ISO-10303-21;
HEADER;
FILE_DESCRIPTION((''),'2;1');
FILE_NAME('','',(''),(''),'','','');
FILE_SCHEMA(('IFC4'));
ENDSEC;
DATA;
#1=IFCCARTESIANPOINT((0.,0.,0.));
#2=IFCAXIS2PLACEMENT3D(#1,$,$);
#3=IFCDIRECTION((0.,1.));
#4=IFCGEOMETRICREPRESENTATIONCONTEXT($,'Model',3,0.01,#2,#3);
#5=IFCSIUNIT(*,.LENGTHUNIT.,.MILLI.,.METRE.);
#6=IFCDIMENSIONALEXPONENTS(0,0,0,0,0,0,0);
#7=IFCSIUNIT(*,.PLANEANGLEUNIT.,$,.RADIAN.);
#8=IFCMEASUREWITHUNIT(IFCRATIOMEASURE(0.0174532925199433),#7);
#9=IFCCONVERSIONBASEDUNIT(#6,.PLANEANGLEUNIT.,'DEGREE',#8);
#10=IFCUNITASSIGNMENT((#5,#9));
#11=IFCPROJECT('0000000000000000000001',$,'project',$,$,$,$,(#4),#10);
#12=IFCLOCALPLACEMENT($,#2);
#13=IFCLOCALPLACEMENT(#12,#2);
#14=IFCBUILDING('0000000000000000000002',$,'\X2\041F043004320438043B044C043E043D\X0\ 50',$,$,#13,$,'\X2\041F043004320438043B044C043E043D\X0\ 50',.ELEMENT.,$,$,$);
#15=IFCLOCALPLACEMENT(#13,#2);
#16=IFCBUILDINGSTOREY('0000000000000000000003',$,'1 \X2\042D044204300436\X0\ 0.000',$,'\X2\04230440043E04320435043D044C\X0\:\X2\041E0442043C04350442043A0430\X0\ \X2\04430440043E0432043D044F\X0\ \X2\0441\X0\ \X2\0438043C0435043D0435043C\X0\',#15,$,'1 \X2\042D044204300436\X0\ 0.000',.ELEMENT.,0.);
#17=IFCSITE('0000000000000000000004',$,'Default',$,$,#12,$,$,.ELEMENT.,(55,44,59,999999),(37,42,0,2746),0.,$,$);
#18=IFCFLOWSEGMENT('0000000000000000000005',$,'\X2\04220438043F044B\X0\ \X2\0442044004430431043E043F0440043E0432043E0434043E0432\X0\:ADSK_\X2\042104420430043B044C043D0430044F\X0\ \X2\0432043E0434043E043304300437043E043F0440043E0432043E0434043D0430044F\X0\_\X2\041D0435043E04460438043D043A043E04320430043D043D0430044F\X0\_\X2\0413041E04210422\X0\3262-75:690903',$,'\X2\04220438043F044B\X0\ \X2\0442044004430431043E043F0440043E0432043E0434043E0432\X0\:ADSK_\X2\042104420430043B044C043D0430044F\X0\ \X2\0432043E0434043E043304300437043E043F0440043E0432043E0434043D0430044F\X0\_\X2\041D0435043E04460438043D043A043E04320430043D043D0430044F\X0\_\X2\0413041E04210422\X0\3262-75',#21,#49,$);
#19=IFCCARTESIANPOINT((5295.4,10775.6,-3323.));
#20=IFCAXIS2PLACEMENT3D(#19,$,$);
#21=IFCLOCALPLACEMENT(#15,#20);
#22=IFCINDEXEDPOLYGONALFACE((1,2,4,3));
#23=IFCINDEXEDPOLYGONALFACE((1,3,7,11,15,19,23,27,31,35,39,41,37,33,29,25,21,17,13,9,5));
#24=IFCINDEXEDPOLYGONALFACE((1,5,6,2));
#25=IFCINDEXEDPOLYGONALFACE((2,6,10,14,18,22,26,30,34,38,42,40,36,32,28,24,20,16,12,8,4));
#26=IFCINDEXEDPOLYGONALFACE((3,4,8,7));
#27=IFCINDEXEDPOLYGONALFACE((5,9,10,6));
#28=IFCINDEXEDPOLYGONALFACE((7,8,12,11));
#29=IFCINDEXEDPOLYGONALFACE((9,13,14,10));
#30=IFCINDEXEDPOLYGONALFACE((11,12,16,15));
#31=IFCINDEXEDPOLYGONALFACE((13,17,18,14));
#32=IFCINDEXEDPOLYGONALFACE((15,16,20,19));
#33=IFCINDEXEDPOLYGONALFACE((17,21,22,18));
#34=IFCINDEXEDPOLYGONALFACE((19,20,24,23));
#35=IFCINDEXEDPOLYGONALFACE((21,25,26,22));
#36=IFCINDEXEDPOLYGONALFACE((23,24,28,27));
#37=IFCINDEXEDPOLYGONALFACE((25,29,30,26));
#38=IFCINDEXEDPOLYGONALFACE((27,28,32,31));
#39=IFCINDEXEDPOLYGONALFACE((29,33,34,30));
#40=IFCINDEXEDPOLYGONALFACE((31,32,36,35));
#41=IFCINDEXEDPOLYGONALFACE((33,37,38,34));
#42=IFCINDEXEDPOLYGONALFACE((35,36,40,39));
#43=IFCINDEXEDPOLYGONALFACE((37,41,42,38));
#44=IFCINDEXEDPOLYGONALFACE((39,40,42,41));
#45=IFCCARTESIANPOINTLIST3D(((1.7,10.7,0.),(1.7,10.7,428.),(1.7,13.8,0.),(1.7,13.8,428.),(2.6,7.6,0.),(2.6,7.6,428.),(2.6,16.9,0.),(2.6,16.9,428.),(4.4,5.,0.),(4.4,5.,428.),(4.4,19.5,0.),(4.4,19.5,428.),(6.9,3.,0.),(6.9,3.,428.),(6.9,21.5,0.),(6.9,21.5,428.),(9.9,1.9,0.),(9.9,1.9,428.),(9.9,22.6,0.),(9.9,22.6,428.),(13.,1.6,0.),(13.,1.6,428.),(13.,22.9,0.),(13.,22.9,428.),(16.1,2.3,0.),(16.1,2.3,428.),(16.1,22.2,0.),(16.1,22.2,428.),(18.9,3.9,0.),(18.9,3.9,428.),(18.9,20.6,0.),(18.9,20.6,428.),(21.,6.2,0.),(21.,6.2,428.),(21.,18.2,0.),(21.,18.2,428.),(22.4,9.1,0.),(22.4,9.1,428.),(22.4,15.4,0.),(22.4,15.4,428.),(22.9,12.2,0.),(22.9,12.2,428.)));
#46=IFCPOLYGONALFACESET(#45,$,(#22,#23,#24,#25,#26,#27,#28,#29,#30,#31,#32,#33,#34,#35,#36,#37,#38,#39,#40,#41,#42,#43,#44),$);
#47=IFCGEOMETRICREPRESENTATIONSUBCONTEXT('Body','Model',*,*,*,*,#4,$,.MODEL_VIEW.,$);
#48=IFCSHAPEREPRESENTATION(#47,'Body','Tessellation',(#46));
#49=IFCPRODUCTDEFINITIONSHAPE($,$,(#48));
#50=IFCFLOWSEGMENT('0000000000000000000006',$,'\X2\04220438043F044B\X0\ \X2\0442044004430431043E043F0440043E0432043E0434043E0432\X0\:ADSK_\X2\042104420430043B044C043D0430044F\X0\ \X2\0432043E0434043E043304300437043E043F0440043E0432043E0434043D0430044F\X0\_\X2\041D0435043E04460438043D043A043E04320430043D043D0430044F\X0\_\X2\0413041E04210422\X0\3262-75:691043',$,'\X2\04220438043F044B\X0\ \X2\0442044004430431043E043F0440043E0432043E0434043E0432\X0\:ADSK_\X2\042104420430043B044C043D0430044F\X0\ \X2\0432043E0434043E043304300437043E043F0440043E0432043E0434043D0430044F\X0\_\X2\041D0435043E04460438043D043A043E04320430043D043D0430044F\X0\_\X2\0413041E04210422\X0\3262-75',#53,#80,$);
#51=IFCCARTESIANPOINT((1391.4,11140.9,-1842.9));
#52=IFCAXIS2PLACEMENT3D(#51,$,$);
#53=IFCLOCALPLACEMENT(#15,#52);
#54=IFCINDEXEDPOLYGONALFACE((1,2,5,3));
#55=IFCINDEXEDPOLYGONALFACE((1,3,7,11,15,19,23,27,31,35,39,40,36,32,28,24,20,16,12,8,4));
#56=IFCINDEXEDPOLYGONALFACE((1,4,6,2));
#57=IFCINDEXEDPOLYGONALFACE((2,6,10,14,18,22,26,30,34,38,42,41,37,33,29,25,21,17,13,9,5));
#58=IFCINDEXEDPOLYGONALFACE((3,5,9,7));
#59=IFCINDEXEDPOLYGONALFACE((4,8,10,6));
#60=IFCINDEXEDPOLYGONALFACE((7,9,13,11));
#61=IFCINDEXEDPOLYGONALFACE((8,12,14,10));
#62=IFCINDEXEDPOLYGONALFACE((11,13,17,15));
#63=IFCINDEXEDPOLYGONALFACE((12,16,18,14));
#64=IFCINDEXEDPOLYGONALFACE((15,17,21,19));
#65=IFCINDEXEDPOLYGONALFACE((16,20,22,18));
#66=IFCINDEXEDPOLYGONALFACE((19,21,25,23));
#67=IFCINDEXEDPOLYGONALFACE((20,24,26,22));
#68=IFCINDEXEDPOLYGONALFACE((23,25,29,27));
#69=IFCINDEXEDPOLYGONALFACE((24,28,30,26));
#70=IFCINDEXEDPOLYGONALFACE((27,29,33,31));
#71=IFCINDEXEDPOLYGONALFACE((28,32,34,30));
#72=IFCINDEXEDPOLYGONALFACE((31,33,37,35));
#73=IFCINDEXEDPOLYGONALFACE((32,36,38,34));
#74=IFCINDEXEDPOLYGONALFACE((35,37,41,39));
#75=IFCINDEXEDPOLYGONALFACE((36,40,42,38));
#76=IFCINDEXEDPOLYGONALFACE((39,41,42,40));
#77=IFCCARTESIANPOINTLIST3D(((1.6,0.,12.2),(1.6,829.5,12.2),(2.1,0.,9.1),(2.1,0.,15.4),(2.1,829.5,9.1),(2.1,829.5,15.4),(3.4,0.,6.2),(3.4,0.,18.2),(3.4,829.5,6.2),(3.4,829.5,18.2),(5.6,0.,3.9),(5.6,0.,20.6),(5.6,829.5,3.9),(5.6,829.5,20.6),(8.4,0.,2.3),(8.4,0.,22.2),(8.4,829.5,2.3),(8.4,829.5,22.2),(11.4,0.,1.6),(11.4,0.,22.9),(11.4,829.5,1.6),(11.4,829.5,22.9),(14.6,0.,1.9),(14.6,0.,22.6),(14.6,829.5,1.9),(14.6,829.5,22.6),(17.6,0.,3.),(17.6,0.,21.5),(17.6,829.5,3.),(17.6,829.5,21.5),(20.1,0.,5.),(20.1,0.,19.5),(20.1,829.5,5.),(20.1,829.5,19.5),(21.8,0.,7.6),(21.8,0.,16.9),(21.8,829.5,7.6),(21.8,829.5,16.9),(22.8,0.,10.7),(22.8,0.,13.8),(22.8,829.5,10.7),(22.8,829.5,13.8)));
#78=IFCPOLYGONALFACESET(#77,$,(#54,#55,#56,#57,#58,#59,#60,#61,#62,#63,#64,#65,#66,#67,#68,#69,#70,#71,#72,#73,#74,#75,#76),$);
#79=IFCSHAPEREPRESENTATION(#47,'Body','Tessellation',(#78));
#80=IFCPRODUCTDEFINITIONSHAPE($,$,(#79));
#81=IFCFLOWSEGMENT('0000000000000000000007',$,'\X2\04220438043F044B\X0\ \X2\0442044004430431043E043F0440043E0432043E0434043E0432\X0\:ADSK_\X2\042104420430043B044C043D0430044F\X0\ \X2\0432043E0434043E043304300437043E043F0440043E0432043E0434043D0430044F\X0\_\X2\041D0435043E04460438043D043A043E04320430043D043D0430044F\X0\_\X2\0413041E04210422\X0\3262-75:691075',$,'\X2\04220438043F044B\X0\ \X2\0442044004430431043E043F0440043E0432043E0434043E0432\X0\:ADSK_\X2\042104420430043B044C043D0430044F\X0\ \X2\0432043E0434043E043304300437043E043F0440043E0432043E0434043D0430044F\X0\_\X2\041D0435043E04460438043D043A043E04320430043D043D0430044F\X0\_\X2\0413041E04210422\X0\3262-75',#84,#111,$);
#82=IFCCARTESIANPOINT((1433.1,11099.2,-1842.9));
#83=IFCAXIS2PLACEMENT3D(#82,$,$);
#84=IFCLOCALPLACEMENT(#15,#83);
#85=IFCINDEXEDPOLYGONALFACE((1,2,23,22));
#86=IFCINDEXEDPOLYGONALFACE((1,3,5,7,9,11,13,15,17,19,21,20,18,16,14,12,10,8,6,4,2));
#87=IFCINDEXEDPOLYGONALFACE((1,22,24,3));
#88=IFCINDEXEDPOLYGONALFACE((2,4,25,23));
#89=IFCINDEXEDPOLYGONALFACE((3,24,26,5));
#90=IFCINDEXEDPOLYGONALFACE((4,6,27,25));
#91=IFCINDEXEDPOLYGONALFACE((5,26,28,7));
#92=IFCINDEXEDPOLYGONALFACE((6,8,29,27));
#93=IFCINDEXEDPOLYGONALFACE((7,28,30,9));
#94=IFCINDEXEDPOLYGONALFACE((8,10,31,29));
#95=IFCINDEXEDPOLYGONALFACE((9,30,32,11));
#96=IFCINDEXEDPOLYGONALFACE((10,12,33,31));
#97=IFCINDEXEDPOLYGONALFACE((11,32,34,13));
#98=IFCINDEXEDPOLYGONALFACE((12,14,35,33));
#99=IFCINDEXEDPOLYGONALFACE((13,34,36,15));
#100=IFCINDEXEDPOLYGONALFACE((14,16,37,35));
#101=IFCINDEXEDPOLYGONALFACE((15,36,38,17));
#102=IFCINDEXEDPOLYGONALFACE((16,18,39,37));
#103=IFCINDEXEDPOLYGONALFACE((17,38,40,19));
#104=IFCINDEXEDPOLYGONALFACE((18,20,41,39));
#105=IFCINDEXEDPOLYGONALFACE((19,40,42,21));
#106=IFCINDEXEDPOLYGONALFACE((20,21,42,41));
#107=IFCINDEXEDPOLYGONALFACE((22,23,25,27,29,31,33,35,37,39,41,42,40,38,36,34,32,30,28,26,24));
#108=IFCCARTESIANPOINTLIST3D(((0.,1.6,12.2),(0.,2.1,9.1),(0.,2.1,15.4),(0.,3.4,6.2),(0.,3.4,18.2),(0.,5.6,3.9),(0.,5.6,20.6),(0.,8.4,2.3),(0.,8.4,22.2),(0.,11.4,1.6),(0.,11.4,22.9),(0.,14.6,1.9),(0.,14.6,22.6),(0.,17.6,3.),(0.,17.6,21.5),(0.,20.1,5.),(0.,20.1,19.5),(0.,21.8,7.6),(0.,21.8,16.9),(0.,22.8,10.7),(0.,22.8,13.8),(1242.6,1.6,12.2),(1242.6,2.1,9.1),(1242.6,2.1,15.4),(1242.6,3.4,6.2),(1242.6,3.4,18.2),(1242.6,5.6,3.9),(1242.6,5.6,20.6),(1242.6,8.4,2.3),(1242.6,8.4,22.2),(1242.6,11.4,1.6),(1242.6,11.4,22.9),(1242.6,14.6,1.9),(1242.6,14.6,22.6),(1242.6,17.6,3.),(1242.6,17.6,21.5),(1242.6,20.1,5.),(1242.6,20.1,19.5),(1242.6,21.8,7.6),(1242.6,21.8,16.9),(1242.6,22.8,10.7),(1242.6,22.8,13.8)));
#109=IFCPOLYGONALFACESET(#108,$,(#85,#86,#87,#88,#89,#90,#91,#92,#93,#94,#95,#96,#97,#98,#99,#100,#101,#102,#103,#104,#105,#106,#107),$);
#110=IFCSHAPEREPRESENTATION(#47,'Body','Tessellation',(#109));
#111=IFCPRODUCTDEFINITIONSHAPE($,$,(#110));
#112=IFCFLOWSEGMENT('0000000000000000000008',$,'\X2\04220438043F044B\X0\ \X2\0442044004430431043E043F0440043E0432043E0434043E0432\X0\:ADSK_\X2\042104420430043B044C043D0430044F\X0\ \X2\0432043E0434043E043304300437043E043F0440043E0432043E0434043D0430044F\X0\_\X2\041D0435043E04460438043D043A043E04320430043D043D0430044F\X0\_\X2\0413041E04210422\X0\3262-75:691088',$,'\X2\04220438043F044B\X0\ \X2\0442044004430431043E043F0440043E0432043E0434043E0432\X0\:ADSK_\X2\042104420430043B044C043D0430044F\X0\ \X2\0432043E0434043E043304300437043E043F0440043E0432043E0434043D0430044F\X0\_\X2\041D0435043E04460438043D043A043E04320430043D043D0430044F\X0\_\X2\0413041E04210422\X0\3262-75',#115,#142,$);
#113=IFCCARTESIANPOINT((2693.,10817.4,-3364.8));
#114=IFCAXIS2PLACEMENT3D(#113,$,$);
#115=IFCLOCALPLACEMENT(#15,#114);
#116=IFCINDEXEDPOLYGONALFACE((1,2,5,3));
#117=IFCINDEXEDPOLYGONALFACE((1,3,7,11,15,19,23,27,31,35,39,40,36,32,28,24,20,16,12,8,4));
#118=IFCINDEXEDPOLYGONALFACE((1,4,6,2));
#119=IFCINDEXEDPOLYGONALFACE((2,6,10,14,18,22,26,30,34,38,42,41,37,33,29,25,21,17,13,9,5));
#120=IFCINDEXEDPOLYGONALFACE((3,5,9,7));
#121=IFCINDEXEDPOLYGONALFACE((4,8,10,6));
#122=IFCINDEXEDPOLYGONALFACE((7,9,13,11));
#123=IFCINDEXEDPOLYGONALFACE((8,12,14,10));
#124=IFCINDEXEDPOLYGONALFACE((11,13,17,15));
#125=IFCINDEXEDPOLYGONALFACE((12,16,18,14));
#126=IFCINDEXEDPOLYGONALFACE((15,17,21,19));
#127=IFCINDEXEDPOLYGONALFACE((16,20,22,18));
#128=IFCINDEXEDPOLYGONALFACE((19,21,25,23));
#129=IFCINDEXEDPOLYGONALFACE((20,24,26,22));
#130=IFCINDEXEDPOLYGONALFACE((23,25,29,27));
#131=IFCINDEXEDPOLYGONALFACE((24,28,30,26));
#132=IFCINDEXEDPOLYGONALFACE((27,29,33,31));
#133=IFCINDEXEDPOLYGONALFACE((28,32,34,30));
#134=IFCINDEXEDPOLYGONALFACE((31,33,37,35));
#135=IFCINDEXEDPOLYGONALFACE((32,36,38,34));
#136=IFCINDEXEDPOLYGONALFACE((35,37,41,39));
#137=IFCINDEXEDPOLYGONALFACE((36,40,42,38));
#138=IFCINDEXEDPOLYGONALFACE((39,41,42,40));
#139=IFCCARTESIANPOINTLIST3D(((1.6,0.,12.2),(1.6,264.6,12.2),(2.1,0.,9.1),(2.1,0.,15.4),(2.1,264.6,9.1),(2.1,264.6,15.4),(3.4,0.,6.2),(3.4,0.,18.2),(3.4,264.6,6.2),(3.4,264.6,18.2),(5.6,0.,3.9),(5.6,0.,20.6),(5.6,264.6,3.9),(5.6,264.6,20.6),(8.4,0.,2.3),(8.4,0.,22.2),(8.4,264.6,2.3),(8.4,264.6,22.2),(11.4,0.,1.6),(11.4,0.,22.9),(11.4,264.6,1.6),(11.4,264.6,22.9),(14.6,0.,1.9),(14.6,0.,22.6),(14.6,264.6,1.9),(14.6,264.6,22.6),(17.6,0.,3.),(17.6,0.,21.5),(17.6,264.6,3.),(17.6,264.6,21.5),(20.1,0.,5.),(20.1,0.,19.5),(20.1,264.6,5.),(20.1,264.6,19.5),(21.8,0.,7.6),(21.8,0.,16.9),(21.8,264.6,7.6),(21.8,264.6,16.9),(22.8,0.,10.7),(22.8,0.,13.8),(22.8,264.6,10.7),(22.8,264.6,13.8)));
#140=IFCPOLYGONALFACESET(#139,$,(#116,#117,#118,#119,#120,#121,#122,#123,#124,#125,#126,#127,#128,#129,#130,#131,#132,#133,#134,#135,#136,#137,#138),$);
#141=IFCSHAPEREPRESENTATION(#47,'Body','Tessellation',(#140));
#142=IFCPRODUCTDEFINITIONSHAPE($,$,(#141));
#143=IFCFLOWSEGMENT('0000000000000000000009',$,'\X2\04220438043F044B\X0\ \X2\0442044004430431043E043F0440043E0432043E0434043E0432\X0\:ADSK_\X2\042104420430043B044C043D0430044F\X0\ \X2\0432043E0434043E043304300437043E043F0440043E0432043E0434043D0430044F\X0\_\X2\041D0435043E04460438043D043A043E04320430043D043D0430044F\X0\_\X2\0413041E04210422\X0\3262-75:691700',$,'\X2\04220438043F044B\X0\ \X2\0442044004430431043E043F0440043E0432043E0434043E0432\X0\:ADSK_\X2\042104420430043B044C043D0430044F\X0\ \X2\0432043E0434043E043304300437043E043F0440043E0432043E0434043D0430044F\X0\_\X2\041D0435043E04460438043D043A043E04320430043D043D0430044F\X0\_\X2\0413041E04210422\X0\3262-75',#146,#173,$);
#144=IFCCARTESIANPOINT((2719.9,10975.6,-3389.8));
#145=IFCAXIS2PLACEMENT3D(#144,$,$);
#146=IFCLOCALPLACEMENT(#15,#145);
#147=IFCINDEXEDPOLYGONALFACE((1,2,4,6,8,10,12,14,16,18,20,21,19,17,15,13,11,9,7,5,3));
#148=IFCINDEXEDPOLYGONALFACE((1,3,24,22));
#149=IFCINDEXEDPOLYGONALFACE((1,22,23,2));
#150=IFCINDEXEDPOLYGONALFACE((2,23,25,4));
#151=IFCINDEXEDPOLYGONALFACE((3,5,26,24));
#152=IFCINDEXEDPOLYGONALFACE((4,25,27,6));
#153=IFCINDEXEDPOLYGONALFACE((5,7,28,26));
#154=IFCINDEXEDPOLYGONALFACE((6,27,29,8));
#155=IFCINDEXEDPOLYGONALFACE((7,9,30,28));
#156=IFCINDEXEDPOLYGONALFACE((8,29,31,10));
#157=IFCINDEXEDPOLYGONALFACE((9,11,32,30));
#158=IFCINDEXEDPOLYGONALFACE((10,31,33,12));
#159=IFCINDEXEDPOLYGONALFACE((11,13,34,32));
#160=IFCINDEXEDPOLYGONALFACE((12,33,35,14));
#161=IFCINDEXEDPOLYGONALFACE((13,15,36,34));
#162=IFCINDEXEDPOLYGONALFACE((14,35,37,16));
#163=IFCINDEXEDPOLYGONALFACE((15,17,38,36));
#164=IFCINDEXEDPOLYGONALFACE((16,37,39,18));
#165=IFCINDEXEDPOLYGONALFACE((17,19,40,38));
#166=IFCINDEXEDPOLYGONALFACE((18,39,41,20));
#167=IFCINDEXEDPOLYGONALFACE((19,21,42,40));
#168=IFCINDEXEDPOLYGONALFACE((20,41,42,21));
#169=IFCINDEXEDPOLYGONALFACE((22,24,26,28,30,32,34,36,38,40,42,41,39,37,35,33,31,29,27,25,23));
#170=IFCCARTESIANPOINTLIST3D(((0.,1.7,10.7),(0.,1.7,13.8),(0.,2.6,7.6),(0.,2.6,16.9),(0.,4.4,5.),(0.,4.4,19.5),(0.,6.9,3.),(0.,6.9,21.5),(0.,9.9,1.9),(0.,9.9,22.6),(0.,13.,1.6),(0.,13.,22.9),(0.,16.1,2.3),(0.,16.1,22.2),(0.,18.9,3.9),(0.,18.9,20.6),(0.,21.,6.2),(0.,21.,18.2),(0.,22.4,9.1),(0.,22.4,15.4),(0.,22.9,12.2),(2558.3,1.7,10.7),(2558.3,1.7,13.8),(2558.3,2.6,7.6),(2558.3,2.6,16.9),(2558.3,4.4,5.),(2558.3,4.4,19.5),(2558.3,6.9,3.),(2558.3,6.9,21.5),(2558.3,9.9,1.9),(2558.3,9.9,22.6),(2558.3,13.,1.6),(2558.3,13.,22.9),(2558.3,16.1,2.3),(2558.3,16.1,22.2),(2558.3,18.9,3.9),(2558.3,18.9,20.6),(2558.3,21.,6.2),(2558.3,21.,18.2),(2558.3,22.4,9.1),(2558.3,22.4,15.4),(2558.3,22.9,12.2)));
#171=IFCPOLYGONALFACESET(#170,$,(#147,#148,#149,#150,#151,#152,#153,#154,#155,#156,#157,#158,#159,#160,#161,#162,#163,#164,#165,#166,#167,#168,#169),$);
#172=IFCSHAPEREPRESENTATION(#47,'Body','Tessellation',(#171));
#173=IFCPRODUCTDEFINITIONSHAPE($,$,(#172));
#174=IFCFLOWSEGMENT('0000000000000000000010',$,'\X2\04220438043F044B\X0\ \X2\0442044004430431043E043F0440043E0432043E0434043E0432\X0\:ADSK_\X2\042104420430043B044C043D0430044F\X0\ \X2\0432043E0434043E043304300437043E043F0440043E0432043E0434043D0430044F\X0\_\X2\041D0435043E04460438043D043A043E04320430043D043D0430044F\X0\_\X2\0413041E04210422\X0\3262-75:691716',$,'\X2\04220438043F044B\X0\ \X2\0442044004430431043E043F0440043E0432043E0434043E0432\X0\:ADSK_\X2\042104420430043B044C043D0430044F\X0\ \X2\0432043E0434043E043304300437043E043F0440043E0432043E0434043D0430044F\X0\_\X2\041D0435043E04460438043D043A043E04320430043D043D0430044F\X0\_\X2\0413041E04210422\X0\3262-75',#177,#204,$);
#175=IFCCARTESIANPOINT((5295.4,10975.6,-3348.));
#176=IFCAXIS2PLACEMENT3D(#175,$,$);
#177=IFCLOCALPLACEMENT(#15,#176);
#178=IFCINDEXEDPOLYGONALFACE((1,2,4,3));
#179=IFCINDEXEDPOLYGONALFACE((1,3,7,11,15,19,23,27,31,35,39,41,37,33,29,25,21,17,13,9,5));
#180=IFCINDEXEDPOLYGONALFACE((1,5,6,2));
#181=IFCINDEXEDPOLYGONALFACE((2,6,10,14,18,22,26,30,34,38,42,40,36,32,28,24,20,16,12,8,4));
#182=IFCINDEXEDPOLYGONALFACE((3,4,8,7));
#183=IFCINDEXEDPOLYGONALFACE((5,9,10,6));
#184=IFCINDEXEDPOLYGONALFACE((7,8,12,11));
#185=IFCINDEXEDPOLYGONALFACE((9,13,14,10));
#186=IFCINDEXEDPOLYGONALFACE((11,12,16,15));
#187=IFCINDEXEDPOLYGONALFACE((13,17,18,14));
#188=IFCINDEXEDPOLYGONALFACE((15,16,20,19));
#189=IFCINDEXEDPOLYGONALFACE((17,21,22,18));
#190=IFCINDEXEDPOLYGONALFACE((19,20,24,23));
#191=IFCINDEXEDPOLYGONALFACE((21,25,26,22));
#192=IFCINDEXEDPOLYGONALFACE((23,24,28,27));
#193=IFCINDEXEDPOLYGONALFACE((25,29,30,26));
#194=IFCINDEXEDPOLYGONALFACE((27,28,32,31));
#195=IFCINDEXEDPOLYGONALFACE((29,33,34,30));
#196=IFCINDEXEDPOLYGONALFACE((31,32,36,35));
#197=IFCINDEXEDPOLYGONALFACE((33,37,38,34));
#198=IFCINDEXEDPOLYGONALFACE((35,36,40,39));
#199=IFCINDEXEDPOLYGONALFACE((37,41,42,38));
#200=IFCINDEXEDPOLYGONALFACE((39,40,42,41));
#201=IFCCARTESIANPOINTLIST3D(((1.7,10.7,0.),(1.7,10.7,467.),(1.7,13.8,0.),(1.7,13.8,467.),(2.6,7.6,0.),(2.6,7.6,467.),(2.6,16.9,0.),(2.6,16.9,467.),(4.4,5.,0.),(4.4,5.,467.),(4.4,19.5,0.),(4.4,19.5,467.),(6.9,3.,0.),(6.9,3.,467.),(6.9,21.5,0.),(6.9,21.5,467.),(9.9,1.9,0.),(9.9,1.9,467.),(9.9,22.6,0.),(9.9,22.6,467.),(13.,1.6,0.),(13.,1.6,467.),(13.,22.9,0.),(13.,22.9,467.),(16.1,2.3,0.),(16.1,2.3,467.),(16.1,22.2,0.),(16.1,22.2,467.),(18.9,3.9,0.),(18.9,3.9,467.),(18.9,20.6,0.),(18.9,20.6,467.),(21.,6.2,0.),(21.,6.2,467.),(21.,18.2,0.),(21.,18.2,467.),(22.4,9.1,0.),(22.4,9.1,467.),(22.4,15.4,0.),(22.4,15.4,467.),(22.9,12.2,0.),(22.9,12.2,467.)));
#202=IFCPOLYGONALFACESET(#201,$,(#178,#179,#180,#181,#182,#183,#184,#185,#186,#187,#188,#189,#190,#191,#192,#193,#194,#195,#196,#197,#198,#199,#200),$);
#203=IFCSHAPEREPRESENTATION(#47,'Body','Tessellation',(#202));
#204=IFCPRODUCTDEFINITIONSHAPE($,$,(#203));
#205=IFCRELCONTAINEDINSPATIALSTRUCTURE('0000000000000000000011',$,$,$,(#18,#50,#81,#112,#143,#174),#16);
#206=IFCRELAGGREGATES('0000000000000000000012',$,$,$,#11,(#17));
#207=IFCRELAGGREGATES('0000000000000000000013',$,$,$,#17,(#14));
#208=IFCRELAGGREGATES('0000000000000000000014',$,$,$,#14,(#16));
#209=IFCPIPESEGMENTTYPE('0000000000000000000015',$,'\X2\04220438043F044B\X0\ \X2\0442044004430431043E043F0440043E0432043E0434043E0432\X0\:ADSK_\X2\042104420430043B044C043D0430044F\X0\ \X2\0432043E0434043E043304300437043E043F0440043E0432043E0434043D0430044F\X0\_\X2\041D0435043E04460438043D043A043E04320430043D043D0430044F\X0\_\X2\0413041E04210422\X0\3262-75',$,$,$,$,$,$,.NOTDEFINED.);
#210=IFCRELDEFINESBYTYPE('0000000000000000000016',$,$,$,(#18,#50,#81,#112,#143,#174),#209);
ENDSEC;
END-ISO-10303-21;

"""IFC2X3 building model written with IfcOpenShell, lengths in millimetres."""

from ifc_helpers import new_model, entity, si_unit, converted_unit, direction, frame, frame_2d, origin, origin_2d_with_axis, place, context, subcontext, project, spatial, circle, extrude, type_object, element, save


model = new_model("IFC2X3")

# Units and contexts
model_context = context("Model", 3, precision=0.01, world=origin(), true_north=direction((0.0, 1.0)))
body_context = subcontext(model_context, "Body", "Model", "MODEL_VIEW")
ifc_project = project(units=[si_unit("LENGTHUNIT", "METRE", prefix="MILLI"), converted_unit("PLANEANGLEUNIT", "DEGREE", entity("IfcRatioMeasure", 0.0174532925199433), si_unit("PLANEANGLEUNIT", "RADIAN"), dimensions=[0, 0, 0, 0, 0, 0, 0])], contexts=[model_context])

# Site, building, storey
site_placement = place(None, origin())
site = spatial("IfcSite", under=ifc_project, at=site_placement, Name="Default", CompositionType="ELEMENT", RefLatitude=(55, 44, 59, 999999), RefLongitude=(37, 42, 0, 2746), RefElevation=0.0)
building_placement = place(site_placement, origin())
building = spatial("IfcBuilding", under=site, at=building_placement, Name="Павильон 50", LongName="Павильон 50", CompositionType="ELEMENT")
storey_placement = place(building_placement, origin())
storey = spatial("IfcBuildingStorey", under=building, at=storey_placement, Name="1 Этаж 0.000", ObjectType="Уровень:Отметка уровня с именем", LongName="1 Этаж 0.000", CompositionType="ELEMENT", Elevation=0.0)

# Flow segments
pipe_segment_type = type_object("IfcPipeSegmentType", Name="Типы трубопроводов:ADSK_Стальная водогазопроводная_Неоцинкованная_ГОСТ3262-75", PredefinedType="NOTDEFINED")
flow_segment_1_placement = place(storey_placement, frame((5295.4, 10775.6, -3323.0)))
element("IfcFlowSegment", 1, at=flow_segment_1_placement, inside=storey, type_object=pipe_segment_type, Name="Типы трубопроводов:ADSK_Стальная водогазопроводная_Неоцинкованная_ГОСТ3262-75:690903", ObjectType="Типы трубопроводов:ADSK_Стальная водогазопроводная_Неоцинкованная_ГОСТ3262-75", context=body_context, shape_type="SweptSolid", body=[
    extrude(circle(Radius=10.7, at=origin_2d_with_axis()), frame((12.2, 12.2, 0.0)), (0.0, 0.0, 1.0), 428.0),
])
flow_segment_2_placement = place(storey_placement, frame((1391.4, 11140.9, -1842.9)))
element("IfcFlowSegment", 2, at=flow_segment_2_placement, inside=storey, type_object=pipe_segment_type, Name="Типы трубопроводов:ADSK_Стальная водогазопроводная_Неоцинкованная_ГОСТ3262-75:691043", ObjectType="Типы трубопроводов:ADSK_Стальная водогазопроводная_Неоцинкованная_ГОСТ3262-75", context=body_context, shape_type="SweptSolid", body=[
    extrude(circle(Radius=10.7, at=frame_2d((0.0, 0.0), x_axis=(1.0, 0.0))), frame((12.2, 0.0, 12.2), z_axis=(0.0, 1.0, 0.0), x_axis=(-1.0, 0.0, 0.0)), (0.0, 0.0, 1.0), 829.5),
])
flow_segment_3_placement = place(storey_placement, frame((1433.1, 11099.2, -1842.9)))
element("IfcFlowSegment", 3, at=flow_segment_3_placement, inside=storey, type_object=pipe_segment_type, Name="Типы трубопроводов:ADSK_Стальная водогазопроводная_Неоцинкованная_ГОСТ3262-75:691075", ObjectType="Типы трубопроводов:ADSK_Стальная водогазопроводная_Неоцинкованная_ГОСТ3262-75", context=body_context, shape_type="SweptSolid", body=[
    extrude(circle(Radius=10.7, at=origin_2d_with_axis()), frame((0.0, 12.2, 12.2), z_axis=(1.0, 0.0, 0.0), x_axis=(0.0, -1.0, 0.0)), (0.0, 0.0, 1.0), 1242.6),
])
flow_segment_4_placement = place(storey_placement, frame((2693.0, 10817.4, -3364.8)))
element("IfcFlowSegment", 4, at=flow_segment_4_placement, inside=storey, type_object=pipe_segment_type, Name="Типы трубопроводов:ADSK_Стальная водогазопроводная_Неоцинкованная_ГОСТ3262-75:691088", ObjectType="Типы трубопроводов:ADSK_Стальная водогазопроводная_Неоцинкованная_ГОСТ3262-75", context=body_context, shape_type="SweptSolid", body=[
    extrude(circle(Radius=10.7, at=frame_2d((0.0, 0.0), x_axis=(1.0, 0.0))), frame((12.2, 0.0, 12.2), z_axis=(0.0, 1.0, 0.0), x_axis=(-1.0, 0.0, 0.0)), (0.0, 0.0, 1.0), 264.6),
])
flow_segment_5_placement = place(storey_placement, frame((2719.9, 10975.6, -3389.8)))
element("IfcFlowSegment", 5, at=flow_segment_5_placement, inside=storey, type_object=pipe_segment_type, Name="Типы трубопроводов:ADSK_Стальная водогазопроводная_Неоцинкованная_ГОСТ3262-75:691700", ObjectType="Типы трубопроводов:ADSK_Стальная водогазопроводная_Неоцинкованная_ГОСТ3262-75", context=body_context, shape_type="SweptSolid", body=[
    extrude(circle(Radius=10.7, at=origin_2d_with_axis()), frame((0.0, 12.2, 12.2), z_axis=(1.0, 0.0, 0.0), x_axis=(0.0, 1.0, 0.0)), (0.0, 0.0, 1.0), 2558.3),
])
flow_segment_6_placement = place(storey_placement, frame((5295.4, 10975.6, -3348.0)))
element("IfcFlowSegment", 6, at=flow_segment_6_placement, inside=storey, type_object=pipe_segment_type, Name="Типы трубопроводов:ADSK_Стальная водогазопроводная_Неоцинкованная_ГОСТ3262-75:691716", ObjectType="Типы трубопроводов:ADSK_Стальная водогазопроводная_Неоцинкованная_ГОСТ3262-75", context=body_context, shape_type="SweptSolid", body=[
    extrude(circle(Radius=10.7, at=origin_2d_with_axis()), frame((12.2, 12.2, 0.0)), (0.0, 0.0, 1.0), 467.0),
])

save(model, "model.ifc")
